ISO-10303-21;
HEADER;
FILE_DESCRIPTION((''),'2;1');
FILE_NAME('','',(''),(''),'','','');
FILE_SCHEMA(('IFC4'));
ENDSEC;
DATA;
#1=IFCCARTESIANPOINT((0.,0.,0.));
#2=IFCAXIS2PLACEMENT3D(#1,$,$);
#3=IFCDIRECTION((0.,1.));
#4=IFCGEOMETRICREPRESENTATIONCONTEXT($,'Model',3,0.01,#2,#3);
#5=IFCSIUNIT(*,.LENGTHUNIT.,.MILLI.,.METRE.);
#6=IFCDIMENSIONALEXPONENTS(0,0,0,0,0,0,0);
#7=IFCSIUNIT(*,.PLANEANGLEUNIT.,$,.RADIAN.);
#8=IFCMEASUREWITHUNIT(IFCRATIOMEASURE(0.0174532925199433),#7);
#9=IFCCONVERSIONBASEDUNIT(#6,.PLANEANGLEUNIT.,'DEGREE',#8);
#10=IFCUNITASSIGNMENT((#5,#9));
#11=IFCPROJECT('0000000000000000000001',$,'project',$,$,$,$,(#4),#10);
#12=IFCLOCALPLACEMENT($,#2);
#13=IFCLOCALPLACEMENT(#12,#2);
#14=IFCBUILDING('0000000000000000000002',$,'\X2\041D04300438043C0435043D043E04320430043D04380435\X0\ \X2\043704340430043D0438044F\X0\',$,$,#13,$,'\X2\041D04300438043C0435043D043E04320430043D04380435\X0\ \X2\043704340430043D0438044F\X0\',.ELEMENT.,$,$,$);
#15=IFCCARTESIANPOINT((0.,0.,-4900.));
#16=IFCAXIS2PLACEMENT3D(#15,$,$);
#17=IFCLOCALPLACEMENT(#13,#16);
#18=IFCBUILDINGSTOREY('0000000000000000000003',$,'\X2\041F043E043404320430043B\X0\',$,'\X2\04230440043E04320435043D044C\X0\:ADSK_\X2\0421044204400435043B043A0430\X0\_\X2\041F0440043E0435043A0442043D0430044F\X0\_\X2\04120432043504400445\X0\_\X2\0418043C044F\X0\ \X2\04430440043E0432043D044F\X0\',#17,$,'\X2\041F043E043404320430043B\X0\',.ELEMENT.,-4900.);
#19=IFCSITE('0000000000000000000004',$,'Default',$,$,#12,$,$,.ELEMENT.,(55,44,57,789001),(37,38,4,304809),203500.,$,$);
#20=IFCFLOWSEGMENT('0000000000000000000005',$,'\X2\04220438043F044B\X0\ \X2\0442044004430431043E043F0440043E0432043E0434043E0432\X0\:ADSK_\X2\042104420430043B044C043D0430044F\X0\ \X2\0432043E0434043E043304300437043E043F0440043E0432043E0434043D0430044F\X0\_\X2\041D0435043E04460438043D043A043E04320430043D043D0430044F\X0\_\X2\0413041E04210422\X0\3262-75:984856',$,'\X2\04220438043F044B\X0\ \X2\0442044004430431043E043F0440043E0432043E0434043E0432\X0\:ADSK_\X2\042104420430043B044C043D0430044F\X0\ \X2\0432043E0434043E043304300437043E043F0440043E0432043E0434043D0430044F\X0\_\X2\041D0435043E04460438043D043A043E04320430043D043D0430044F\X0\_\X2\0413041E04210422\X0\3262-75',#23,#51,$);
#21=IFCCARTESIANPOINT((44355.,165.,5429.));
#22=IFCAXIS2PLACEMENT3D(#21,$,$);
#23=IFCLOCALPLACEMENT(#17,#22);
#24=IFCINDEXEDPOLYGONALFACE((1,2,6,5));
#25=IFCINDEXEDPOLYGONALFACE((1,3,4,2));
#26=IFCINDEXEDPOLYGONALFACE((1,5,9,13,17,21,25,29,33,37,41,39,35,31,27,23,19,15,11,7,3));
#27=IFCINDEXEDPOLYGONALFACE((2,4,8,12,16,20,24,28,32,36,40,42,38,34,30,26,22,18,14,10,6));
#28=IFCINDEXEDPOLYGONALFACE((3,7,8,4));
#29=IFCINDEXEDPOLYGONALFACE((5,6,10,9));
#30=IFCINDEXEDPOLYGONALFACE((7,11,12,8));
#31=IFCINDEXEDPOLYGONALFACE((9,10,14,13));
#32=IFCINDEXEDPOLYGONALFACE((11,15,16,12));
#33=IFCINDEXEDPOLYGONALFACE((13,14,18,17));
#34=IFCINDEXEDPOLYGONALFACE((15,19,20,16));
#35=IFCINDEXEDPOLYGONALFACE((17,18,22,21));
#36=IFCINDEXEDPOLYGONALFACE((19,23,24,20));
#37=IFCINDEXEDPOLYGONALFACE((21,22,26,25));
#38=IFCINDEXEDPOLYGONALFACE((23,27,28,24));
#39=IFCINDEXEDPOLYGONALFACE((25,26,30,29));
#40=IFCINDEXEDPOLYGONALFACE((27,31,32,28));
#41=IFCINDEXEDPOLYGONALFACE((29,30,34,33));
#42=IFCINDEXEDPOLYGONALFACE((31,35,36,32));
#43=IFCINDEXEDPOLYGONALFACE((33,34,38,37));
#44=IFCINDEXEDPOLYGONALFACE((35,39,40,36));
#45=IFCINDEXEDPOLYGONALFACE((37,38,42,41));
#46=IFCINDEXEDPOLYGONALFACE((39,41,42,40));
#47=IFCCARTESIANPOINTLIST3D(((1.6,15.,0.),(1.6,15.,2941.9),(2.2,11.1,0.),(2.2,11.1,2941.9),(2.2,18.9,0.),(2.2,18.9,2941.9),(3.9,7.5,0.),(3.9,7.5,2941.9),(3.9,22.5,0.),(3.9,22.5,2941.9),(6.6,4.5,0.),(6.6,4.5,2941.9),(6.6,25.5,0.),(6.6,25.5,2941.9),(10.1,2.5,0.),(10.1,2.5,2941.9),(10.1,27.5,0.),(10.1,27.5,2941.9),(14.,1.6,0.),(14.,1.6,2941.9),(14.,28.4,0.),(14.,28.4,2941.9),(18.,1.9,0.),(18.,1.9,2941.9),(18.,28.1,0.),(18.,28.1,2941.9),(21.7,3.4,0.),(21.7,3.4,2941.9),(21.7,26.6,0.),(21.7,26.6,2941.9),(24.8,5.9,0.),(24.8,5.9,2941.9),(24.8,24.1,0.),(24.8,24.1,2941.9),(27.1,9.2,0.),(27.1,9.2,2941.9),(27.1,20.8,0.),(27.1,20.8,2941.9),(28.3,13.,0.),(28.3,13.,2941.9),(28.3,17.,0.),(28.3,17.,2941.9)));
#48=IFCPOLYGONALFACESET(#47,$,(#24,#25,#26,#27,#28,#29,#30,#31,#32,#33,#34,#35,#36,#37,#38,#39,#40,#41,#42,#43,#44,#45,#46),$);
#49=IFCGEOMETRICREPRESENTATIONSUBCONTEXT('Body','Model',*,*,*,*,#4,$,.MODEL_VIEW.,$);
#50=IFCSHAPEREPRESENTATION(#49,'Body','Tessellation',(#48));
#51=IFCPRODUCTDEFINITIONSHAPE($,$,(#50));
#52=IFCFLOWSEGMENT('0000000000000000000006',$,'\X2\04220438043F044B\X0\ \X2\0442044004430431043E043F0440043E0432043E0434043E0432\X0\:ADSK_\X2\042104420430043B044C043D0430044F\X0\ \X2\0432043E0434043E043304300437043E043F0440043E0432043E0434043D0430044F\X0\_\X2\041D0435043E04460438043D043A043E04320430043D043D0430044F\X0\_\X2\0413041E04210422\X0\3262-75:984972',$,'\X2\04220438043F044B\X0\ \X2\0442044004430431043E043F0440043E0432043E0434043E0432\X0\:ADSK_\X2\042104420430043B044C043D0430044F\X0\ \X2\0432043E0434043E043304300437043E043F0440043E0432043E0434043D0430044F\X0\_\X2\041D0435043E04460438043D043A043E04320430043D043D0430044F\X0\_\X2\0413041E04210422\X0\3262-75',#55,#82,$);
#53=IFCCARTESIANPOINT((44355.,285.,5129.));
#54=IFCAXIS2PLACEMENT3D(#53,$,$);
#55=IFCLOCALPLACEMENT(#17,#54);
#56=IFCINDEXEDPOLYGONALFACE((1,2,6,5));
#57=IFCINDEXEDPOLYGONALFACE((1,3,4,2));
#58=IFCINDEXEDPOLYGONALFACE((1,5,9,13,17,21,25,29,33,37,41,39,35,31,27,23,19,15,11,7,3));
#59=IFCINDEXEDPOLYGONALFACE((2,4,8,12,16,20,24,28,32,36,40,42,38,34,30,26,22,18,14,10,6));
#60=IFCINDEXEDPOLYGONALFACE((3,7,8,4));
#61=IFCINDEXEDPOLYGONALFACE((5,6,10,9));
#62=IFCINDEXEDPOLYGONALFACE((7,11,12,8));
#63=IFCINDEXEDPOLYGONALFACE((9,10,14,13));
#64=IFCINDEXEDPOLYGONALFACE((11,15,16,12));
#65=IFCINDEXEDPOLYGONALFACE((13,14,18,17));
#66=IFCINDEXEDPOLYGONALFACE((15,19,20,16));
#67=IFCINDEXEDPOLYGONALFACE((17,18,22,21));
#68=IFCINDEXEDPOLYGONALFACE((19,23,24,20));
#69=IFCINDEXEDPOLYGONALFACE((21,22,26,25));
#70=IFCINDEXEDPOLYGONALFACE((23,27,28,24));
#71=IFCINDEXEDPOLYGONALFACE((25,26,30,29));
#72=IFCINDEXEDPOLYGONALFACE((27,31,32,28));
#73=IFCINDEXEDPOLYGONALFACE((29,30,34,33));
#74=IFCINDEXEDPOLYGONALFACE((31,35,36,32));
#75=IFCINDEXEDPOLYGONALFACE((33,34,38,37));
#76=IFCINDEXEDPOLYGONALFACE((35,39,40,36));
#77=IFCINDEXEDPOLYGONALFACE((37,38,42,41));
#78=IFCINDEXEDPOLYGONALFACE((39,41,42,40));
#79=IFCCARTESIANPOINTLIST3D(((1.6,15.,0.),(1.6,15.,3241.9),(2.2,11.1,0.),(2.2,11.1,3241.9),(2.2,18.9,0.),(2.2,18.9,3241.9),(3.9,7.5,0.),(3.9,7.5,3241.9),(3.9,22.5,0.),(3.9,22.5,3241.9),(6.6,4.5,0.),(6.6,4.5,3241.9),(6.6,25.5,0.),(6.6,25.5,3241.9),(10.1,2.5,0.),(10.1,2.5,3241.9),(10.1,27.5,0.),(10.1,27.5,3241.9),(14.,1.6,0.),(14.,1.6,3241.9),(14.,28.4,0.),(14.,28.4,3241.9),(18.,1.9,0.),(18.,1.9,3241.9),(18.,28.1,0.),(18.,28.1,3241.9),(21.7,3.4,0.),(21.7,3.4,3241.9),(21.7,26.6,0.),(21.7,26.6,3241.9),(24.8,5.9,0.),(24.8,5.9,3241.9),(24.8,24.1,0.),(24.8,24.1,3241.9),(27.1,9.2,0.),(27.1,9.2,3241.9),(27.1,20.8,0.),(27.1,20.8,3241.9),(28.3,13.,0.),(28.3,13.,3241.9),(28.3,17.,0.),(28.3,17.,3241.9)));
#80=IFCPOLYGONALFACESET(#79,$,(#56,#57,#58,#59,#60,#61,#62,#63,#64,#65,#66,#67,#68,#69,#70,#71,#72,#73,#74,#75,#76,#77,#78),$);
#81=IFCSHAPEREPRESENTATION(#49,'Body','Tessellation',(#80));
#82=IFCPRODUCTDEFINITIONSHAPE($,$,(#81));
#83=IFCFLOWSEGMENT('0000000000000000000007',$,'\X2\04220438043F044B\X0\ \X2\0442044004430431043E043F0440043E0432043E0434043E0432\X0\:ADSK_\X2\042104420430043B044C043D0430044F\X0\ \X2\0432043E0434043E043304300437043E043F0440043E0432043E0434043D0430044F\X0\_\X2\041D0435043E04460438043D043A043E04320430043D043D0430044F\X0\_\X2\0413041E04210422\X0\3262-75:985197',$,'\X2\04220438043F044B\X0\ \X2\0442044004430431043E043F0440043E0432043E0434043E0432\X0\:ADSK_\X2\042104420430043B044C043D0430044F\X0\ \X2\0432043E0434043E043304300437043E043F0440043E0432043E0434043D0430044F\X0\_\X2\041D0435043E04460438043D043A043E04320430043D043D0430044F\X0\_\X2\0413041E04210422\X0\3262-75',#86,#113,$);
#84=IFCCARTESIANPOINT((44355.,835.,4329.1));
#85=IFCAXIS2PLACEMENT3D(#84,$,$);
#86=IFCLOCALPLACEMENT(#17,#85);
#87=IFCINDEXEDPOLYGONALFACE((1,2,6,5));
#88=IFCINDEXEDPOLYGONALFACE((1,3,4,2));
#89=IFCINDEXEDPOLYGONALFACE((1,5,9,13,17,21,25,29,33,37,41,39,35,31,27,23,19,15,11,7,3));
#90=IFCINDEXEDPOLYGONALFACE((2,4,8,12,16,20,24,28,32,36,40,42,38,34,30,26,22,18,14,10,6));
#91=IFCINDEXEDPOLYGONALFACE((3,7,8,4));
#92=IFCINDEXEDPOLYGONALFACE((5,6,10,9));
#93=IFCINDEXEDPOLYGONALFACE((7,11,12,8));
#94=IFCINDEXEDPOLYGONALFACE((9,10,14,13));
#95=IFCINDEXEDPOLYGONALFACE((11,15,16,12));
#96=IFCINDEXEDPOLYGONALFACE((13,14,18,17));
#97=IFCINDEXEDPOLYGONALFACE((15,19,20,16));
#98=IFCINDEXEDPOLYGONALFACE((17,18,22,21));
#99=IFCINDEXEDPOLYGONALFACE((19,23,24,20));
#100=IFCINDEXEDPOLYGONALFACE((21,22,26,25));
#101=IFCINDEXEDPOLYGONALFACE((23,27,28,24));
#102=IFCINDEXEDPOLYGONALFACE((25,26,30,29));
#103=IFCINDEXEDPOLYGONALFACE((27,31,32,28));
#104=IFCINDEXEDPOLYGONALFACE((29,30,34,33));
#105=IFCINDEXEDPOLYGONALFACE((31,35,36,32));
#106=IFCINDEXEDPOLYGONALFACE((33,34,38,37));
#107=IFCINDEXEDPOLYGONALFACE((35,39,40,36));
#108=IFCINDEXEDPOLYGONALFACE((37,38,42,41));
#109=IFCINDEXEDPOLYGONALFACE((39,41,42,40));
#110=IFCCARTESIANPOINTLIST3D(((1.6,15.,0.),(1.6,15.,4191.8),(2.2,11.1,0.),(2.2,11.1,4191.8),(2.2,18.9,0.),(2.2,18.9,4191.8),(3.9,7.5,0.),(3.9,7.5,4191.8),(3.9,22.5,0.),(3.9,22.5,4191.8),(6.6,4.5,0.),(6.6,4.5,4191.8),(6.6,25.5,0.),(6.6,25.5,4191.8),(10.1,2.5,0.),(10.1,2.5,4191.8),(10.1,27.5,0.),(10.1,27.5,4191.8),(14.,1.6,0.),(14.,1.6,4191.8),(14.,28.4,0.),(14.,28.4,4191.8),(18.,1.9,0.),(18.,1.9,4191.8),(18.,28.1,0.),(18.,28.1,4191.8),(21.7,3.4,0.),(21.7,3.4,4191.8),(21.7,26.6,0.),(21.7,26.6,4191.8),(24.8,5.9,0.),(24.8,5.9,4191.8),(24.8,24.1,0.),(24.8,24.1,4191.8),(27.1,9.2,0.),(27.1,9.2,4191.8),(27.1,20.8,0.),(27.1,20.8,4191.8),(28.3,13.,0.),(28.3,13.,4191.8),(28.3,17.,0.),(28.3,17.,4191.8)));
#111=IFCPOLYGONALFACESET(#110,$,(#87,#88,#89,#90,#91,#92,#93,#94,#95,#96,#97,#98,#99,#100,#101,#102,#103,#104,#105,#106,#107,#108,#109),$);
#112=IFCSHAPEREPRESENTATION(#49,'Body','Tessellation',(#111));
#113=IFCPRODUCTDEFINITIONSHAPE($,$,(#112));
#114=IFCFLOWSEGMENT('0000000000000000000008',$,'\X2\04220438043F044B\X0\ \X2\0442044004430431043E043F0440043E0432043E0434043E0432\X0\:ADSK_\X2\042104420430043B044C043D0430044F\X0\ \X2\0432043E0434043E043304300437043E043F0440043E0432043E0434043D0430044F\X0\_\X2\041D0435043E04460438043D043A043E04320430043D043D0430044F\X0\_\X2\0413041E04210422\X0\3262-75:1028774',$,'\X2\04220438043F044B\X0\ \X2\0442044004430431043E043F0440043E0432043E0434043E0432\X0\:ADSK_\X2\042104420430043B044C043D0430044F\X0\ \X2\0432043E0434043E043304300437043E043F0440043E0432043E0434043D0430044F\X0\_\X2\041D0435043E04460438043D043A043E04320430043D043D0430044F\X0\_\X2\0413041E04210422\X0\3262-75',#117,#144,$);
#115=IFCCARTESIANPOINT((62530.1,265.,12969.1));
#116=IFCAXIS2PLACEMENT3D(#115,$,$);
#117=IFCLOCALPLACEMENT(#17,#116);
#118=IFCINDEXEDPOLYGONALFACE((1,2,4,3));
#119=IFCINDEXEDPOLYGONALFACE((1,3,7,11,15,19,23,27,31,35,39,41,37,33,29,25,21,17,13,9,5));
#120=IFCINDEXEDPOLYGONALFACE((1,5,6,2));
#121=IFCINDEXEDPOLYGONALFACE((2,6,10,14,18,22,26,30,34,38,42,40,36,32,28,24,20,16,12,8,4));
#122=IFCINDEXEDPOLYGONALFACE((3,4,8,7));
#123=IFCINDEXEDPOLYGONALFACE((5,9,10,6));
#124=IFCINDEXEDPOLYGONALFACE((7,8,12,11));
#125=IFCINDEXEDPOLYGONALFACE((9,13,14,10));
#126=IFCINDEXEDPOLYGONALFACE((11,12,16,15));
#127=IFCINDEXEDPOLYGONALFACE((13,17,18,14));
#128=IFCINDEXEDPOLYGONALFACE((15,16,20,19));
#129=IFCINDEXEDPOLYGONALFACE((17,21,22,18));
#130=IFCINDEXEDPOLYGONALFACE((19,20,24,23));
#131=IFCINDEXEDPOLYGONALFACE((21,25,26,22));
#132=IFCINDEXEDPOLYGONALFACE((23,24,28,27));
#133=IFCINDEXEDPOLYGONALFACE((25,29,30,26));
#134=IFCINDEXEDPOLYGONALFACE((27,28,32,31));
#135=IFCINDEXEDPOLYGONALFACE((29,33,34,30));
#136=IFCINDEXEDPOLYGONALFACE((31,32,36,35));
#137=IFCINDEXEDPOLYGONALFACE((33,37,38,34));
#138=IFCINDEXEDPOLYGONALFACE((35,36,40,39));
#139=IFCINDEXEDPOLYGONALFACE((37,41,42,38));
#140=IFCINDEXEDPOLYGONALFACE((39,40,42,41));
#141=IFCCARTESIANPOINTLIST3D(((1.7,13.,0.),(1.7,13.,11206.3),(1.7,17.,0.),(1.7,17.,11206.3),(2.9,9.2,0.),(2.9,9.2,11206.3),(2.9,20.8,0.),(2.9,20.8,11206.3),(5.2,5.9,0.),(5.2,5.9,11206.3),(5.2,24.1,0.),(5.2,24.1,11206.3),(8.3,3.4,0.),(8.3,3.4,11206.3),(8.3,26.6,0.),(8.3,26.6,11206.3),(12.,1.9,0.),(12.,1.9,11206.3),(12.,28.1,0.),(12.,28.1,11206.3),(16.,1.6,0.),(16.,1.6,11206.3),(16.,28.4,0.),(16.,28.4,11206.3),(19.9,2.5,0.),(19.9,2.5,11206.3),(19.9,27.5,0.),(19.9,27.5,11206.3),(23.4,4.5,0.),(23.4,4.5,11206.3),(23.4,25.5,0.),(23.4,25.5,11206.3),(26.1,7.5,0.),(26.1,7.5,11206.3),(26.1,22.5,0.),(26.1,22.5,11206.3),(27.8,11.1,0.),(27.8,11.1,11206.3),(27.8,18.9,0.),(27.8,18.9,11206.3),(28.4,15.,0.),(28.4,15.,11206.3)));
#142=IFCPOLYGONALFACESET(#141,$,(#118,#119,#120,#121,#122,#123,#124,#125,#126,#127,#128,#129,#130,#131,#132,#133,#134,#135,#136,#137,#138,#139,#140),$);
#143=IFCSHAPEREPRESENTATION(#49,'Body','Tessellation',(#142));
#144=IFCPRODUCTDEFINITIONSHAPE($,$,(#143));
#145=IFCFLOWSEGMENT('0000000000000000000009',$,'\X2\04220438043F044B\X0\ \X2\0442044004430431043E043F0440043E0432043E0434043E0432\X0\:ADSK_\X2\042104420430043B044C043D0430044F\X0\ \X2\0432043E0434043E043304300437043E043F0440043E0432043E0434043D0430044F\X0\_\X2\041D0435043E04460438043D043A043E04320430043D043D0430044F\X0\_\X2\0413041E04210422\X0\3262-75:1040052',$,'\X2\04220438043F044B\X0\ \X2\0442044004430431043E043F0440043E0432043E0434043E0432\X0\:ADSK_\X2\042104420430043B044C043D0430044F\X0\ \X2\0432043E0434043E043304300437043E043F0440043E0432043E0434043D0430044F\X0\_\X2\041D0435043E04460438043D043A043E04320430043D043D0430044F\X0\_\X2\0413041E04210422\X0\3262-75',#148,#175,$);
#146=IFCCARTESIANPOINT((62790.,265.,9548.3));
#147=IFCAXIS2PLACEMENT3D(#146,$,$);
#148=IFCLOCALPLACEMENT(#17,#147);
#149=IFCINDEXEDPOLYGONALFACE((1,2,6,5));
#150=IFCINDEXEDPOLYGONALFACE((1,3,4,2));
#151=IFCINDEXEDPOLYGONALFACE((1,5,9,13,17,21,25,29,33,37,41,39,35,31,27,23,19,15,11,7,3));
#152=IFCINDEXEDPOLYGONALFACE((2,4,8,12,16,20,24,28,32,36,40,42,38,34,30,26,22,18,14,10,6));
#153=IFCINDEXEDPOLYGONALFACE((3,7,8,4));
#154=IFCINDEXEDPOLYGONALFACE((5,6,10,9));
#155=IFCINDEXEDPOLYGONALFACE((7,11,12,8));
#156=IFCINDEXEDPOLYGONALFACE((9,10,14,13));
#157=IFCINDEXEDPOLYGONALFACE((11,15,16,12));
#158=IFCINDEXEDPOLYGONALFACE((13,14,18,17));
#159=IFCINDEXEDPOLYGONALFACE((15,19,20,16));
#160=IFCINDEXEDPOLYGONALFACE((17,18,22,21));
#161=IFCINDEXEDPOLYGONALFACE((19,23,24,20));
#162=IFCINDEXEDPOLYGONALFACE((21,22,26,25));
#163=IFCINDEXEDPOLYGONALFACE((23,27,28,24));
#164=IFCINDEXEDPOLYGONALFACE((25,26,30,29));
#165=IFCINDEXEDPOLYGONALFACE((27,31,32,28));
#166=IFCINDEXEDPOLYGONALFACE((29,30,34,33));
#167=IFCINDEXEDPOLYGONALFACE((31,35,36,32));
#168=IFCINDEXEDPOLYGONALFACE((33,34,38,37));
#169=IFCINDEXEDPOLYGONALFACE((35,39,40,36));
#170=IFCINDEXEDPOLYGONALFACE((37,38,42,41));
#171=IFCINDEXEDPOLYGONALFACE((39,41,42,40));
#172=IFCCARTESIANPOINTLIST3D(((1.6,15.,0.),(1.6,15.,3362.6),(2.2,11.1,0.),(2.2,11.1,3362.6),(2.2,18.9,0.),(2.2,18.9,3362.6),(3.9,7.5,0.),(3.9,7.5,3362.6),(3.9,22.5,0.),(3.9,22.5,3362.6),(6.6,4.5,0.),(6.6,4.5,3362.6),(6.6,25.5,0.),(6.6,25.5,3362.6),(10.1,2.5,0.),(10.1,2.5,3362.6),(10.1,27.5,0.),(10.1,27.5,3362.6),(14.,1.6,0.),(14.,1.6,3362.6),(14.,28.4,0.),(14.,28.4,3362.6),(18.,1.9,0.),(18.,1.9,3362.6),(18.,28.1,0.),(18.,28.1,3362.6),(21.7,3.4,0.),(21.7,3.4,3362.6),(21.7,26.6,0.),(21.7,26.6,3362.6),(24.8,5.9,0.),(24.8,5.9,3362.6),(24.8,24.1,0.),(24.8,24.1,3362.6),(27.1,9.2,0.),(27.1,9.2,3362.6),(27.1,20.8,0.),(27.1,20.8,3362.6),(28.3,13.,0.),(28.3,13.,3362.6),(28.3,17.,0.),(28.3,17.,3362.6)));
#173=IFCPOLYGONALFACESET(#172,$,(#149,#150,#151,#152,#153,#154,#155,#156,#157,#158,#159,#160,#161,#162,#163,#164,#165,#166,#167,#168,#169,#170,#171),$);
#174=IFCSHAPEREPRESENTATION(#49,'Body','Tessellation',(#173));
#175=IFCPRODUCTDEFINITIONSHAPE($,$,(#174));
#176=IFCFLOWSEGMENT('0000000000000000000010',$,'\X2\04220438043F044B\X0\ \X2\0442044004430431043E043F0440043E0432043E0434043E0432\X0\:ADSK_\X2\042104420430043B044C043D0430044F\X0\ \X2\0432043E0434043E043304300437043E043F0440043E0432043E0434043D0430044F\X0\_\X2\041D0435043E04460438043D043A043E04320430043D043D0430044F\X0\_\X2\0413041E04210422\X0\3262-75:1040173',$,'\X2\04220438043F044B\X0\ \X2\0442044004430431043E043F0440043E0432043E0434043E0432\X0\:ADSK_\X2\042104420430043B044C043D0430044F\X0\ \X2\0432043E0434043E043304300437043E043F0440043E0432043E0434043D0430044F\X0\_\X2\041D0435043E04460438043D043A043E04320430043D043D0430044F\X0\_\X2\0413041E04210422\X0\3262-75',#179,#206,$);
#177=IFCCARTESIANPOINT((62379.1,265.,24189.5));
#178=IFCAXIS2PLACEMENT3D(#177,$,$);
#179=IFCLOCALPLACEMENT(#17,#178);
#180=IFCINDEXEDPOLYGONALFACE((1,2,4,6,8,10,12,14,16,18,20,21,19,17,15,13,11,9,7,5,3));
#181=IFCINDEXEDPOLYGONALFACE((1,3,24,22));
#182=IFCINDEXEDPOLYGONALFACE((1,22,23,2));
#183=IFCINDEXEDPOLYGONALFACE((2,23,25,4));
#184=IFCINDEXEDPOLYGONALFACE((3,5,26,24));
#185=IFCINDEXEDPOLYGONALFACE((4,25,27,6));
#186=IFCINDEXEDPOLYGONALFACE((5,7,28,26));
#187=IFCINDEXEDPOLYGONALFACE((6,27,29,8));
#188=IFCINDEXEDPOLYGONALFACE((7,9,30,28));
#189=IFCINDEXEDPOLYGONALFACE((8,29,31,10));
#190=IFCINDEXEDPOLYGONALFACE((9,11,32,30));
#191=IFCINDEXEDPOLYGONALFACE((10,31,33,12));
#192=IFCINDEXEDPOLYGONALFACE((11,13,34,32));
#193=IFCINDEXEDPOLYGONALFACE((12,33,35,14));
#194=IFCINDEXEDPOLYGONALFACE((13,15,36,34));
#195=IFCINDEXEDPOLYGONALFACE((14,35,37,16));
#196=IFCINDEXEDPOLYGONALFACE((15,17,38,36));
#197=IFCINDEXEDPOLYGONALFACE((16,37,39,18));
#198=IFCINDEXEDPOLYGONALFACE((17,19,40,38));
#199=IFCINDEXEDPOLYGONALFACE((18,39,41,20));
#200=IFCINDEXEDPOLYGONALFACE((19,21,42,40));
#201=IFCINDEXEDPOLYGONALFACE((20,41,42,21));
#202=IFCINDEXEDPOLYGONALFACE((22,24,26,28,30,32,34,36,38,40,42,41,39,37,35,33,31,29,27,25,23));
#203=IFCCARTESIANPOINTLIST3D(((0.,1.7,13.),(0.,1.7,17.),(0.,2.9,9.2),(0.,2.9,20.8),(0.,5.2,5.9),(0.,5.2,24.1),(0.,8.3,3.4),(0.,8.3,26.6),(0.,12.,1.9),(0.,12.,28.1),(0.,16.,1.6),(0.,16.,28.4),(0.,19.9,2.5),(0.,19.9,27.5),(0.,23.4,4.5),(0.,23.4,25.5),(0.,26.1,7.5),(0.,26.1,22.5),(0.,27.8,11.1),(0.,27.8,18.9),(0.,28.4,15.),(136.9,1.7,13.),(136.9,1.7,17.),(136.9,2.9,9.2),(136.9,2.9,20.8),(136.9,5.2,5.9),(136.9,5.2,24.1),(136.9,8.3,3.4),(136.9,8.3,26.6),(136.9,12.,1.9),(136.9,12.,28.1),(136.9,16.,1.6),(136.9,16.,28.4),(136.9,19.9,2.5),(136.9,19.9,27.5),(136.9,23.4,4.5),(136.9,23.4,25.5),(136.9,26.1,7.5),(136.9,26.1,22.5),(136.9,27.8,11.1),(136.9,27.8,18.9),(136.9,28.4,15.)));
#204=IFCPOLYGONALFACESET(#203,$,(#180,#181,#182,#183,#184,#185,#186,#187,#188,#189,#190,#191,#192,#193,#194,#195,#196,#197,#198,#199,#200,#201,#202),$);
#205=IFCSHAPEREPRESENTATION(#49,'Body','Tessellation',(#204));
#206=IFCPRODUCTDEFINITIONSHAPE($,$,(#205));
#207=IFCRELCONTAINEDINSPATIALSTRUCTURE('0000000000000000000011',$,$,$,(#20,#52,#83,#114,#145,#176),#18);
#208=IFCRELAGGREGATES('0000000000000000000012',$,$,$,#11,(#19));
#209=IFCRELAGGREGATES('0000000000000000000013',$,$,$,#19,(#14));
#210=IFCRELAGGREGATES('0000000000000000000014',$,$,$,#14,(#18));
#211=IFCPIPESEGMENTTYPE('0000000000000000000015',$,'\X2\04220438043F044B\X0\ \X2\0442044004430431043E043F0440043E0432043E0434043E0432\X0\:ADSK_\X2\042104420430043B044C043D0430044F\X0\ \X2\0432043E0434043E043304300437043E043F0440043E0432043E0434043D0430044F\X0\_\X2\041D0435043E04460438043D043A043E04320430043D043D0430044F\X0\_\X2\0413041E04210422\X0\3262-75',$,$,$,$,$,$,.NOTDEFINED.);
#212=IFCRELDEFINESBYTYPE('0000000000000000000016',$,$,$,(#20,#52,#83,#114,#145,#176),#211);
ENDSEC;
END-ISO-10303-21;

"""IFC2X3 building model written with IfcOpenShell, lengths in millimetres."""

from ifc_helpers import new_model, entity, si_unit, converted_unit, direction, frame, origin, origin_2d_with_axis, place, context, subcontext, project, spatial, circle, extrude, type_object, element, save


model = new_model("IFC2X3")

# Units and contexts
model_context = context("Model", 3, precision=0.01, world=origin(), true_north=direction((0.0, 1.0)))
body_context = subcontext(model_context, "Body", "Model", "MODEL_VIEW")
ifc_project = project(units=[si_unit("LENGTHUNIT", "METRE", prefix="MILLI"), converted_unit("PLANEANGLEUNIT", "DEGREE", entity("IfcRatioMeasure", 0.0174532925199433), si_unit("PLANEANGLEUNIT", "RADIAN"), dimensions=[0, 0, 0, 0, 0, 0, 0])], contexts=[model_context])

# Site, building, storey
site_placement = place(None, origin())
site = spatial("IfcSite", under=ifc_project, at=site_placement, Name="Default", CompositionType="ELEMENT", RefLatitude=(55, 44, 57, 789001), RefLongitude=(37, 38, 4, 304809), RefElevation=203500.0)
building_placement = place(site_placement, origin())
building = spatial("IfcBuilding", under=site, at=building_placement, Name="Наименование здания", LongName="Наименование здания", CompositionType="ELEMENT")
storey_placement = place(building_placement, frame((0.0, 0.0, -4900.0)))
storey = spatial("IfcBuildingStorey", under=building, at=storey_placement, Name="Подвал", ObjectType="Уровень:ADSK_Стрелка_Проектная_Вверх_Имя уровня", LongName="Подвал", CompositionType="ELEMENT", Elevation=-4900.0)

# Flow segments
pipe_segment_type = type_object("IfcPipeSegmentType", Name="Типы трубопроводов:ADSK_Стальная водогазопроводная_Неоцинкованная_ГОСТ3262-75", PredefinedType="NOTDEFINED")
flow_segment_1_placement = place(storey_placement, frame((44355.0, 165.0, 5429.0)))
element("IfcFlowSegment", 1, at=flow_segment_1_placement, inside=storey, type_object=pipe_segment_type, Name="Типы трубопроводов:ADSK_Стальная водогазопроводная_Неоцинкованная_ГОСТ3262-75:984856", ObjectType="Типы трубопроводов:ADSK_Стальная водогазопроводная_Неоцинкованная_ГОСТ3262-75", context=body_context, shape_type="SweptSolid", body=[
    extrude(circle(Radius=13.4, at=origin_2d_with_axis()), frame((15.0, 15.0, 0.0), z_axis=(0.0, 0.0, 1.0), x_axis=(-1.0, 0.0, 0.0)), (0.0, 0.0, 1.0), 2941.9),
])
flow_segment_2_placement = place(storey_placement, frame((44355.0, 285.0, 5129.0)))
element("IfcFlowSegment", 2, at=flow_segment_2_placement, inside=storey, type_object=pipe_segment_type, Name="Типы трубопроводов:ADSK_Стальная водогазопроводная_Неоцинкованная_ГОСТ3262-75:984972", ObjectType="Типы трубопроводов:ADSK_Стальная водогазопроводная_Неоцинкованная_ГОСТ3262-75", context=body_context, shape_type="SweptSolid", body=[
    extrude(circle(Radius=13.4, at=origin_2d_with_axis()), frame((15.0, 15.0, 0.0), z_axis=(0.0, 0.0, 1.0), x_axis=(-1.0, 0.0, 0.0)), (0.0, 0.0, 1.0), 3241.9),
])
flow_segment_3_placement = place(storey_placement, frame((44355.0, 835.0, 4329.1)))
element("IfcFlowSegment", 3, at=flow_segment_3_placement, inside=storey, type_object=pipe_segment_type, Name="Типы трубопроводов:ADSK_Стальная водогазопроводная_Неоцинкованная_ГОСТ3262-75:985197", ObjectType="Типы трубопроводов:ADSK_Стальная водогазопроводная_Неоцинкованная_ГОСТ3262-75", context=body_context, shape_type="SweptSolid", body=[
    extrude(circle(Radius=13.4, at=origin_2d_with_axis()), frame((15.0, 15.0, 0.0), z_axis=(0.0, 0.0, 1.0), x_axis=(-1.0, 0.0, 0.0)), (0.0, 0.0, 1.0), 4191.8),
])
flow_segment_4_placement = place(storey_placement, frame((62530.1, 265.0, 12969.1)))
element("IfcFlowSegment", 4, at=flow_segment_4_placement, inside=storey, type_object=pipe_segment_type, Name="Типы трубопроводов:ADSK_Стальная водогазопроводная_Неоцинкованная_ГОСТ3262-75:1028774", ObjectType="Типы трубопроводов:ADSK_Стальная водогазопроводная_Неоцинкованная_ГОСТ3262-75", context=body_context, shape_type="SweptSolid", body=[
    extrude(circle(Radius=13.4, at=origin_2d_with_axis()), frame((15.0, 15.0, 0.0)), (0.0, 0.0, 1.0), 11206.3),
])
flow_segment_5_placement = place(storey_placement, frame((62790.0, 265.0, 9548.3)))
element("IfcFlowSegment", 5, at=flow_segment_5_placement, inside=storey, type_object=pipe_segment_type, Name="Типы трубопроводов:ADSK_Стальная водогазопроводная_Неоцинкованная_ГОСТ3262-75:1040052", ObjectType="Типы трубопроводов:ADSK_Стальная водогазопроводная_Неоцинкованная_ГОСТ3262-75", context=body_context, shape_type="SweptSolid", body=[
    extrude(circle(Radius=13.4, at=origin_2d_with_axis()), frame((15.0, 15.0, 0.0), z_axis=(0.0, 0.0, 1.0), x_axis=(-1.0, 0.0, 0.0)), (0.0, 0.0, 1.0), 3362.6),
])
flow_segment_6_placement = place(storey_placement, frame((62379.1, 265.0, 24189.5)))
element("IfcFlowSegment", 6, at=flow_segment_6_placement, inside=storey, type_object=pipe_segment_type, Name="Типы трубопроводов:ADSK_Стальная водогазопроводная_Неоцинкованная_ГОСТ3262-75:1040173", ObjectType="Типы трубопроводов:ADSK_Стальная водогазопроводная_Неоцинкованная_ГОСТ3262-75", context=body_context, shape_type="SweptSolid", body=[
    extrude(circle(Radius=13.4, at=origin_2d_with_axis()), frame((0.0, 15.0, 15.0), z_axis=(1.0, 0.0, 0.0), x_axis=(0.0, 1.0, 0.0)), (0.0, 0.0, 1.0), 136.9),
])

save(model, "model.ifc")
